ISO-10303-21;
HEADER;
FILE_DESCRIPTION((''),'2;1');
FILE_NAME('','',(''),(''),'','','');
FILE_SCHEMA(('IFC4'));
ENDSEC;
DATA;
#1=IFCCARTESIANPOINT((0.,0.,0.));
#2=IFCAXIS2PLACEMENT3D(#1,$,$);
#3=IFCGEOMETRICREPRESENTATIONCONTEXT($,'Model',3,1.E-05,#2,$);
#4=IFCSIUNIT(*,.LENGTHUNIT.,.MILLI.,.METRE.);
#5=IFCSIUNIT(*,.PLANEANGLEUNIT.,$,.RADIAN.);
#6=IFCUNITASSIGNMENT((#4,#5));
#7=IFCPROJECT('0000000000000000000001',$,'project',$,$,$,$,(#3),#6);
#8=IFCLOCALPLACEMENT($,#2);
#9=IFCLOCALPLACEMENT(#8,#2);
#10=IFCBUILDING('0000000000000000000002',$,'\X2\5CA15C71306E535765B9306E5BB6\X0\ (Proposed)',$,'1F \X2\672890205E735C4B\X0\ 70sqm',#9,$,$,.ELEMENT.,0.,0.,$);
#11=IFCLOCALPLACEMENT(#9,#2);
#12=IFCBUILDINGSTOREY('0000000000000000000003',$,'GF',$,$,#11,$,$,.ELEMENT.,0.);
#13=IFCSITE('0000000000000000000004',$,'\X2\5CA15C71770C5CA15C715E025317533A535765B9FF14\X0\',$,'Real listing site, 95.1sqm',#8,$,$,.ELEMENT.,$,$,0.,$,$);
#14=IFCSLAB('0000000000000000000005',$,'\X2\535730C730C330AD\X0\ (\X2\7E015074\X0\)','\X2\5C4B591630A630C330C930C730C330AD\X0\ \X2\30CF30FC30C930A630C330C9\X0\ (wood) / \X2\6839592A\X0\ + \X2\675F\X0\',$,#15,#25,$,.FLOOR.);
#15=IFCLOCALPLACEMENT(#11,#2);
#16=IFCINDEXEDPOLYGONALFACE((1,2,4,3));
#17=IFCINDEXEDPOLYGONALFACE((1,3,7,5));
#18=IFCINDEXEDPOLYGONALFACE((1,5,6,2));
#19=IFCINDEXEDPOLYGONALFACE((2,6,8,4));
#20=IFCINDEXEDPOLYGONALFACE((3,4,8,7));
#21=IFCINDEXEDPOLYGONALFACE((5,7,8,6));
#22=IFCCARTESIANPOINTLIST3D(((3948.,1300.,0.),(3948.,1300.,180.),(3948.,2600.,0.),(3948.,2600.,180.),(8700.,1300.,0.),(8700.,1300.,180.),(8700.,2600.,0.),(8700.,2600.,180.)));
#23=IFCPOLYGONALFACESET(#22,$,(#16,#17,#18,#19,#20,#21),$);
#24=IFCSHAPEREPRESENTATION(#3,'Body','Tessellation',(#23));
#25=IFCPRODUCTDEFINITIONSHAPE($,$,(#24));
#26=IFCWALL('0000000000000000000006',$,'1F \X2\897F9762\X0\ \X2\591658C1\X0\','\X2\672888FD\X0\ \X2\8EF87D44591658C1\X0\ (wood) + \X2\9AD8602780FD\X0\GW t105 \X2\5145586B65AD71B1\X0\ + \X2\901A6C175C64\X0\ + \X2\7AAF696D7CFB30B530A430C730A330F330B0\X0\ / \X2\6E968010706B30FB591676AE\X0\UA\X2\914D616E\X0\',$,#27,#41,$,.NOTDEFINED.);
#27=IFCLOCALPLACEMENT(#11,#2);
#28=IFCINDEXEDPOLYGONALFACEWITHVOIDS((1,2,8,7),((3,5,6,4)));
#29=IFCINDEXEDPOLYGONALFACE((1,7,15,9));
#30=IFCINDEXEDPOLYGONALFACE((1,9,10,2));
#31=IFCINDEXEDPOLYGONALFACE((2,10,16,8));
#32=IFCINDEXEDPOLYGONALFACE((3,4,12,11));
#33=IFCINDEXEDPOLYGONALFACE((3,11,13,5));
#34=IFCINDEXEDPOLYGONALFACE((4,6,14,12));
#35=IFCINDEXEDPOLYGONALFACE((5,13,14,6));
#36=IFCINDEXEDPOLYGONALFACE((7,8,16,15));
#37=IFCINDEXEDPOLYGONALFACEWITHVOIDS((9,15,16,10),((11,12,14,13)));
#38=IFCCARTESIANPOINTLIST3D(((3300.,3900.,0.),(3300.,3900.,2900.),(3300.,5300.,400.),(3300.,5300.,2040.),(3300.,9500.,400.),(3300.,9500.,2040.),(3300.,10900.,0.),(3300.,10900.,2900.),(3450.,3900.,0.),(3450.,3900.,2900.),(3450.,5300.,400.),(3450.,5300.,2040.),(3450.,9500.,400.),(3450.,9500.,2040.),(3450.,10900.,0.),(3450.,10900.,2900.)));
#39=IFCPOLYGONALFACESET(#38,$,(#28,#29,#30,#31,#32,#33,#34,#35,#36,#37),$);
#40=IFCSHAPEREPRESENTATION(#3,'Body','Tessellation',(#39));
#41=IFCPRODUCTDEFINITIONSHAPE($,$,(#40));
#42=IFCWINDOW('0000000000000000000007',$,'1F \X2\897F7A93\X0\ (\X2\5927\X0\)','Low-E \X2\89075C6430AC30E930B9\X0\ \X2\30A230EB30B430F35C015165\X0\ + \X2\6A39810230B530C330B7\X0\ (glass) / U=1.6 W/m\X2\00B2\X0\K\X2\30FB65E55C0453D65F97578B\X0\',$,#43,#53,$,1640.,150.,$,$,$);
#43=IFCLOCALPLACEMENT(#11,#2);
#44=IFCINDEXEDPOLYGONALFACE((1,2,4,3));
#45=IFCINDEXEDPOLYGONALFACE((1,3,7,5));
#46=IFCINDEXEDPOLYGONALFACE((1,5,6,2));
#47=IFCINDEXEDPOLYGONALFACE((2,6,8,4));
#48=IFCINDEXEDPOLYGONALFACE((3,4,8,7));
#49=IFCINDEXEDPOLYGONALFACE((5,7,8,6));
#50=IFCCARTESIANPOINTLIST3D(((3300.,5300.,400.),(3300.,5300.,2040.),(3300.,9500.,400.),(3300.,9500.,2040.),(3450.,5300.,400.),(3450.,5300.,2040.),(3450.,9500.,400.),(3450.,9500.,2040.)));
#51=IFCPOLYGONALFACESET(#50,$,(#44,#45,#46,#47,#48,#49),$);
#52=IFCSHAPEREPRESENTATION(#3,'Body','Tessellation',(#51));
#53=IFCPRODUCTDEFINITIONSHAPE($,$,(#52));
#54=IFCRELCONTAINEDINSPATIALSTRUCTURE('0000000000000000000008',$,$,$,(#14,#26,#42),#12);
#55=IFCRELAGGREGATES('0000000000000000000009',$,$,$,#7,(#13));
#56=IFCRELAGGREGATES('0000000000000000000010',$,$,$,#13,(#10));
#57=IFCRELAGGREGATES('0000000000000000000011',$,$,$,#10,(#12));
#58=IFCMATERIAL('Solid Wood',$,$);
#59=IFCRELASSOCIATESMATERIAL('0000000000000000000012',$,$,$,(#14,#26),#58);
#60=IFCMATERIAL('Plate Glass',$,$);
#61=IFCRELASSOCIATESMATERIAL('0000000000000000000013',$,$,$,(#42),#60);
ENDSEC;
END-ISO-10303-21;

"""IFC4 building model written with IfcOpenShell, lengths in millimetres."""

from ifc_helpers import new_model, si_unit, frame, frame_2d, origin, place, context, project, spatial, rectangle, extrude, material, element, fill, save


model = new_model("IFC4")

# Units and contexts
model_context = context("Model", 3, precision=1e-05, world=origin())
ifc_project = project(units=[si_unit("LENGTHUNIT", "METRE", prefix="MILLI"), si_unit("PLANEANGLEUNIT", "RADIAN")], contexts=[model_context])

# Site, building, storey
site_placement = place(None, origin())
site = spatial("IfcSite", under=ifc_project, at=site_placement, Name="岡山県岡山市北区南方４", ObjectType="Real listing site, 95.1sqm", CompositionType="ELEMENT", RefElevation=0.0)
building_placement = place(site_placement, origin())
building = spatial("IfcBuilding", under=site, at=building_placement, Name="岡山の南方の家 (Proposed)", ObjectType="1F 木造平屋 70sqm", CompositionType="ELEMENT", ElevationOfRefHeight=0.0, ElevationOfTerrain=0.0)
storey_placement = place(building_placement, origin())
storey = spatial("IfcBuildingStorey", under=building, at=storey_placement, Name="GF", CompositionType="ELEMENT", Elevation=0.0)

# Slab
ifc_material_1 = material(Name="Solid Wood")
slab_1_placement = place(storey_placement, frame((1974.0, 650.0, 0.0)))
element("IfcSlab", 1, at=slab_1_placement, inside=storey, material=ifc_material_1, Name="南デッキ (縁側)", Description="屋外ウッドデッキ ハードウッド (wood) / 根太 + 束", PredefinedType="FLOOR", context=model_context, shape_type="SweptSolid", body=[
    extrude(rectangle(XDim=4752.0, YDim=1300.0, at=frame_2d((2376.0, 650.0))), frame((1974.0, 650.0, 0.0)), (0.0, 0.0, 1.0), 180.0),
])

# Shared definitions
ifc_material_2 = material(Name="Plate Glass")

# Wall, opening, window
wall_1_placement = place(storey_placement, frame((1650.0, 1950.0, 0.0)))
wall_1 = element("IfcWall", 2, at=wall_1_placement, inside=storey, material=ifc_material_1, Name="1F 西面 外壁", Description="木製 軸組外壁 (wood) + 高性能GW t105 充填断熱 + 通気層 + 窯業系サイディング / 準耐火・外皮UA配慮", PredefinedType="NOTDEFINED", context=model_context, shape_type="SweptSolid", body=[
    extrude(rectangle(XDim=150.0, YDim=7000.0, at=frame_2d((75.0, 3500.0))), frame((1650.0, 1950.0, 0.0)), (0.0, 0.0, 1.0), 2900.0),
])
opening_1_placement = place(storey_placement, frame((1650.0, 2650.0, 200.0)))
opening_1 = element("IfcOpeningElement", 3, at=opening_1_placement, cuts=wall_1, PredefinedType="NOTDEFINED", context=model_context, shape_type="SweptSolid", body=[
    extrude(rectangle(XDim=150.0, YDim=4200.0, at=frame_2d((75.0, 2100.0))), frame((1650.0, 2650.0, 200.0)), (0.0, 0.0, 1.0), 1640.0),
])
window_1_placement = place(storey_placement, frame((1650.0, 2650.0, 200.0)))
window_1 = element("IfcWindow", 4, at=window_1_placement, inside=storey, material=ifc_material_2, Name="1F 西窓 (大)", Description="Low-E 複層ガラス アルゴン封入 + 樹脂サッシ (glass) / U=1.6 W/m²K・日射取得型", OverallHeight=1640.0, OverallWidth=150.0, context=model_context, shape_type="SweptSolid", body=[
    extrude(rectangle(XDim=150.0, YDim=4200.0, at=frame_2d((75.0, 2100.0))), frame((1650.0, 2650.0, 200.0)), (0.0, 0.0, 1.0), 1640.0),
])
fill(opening_1, window_1)

save(model, "model.ifc")
